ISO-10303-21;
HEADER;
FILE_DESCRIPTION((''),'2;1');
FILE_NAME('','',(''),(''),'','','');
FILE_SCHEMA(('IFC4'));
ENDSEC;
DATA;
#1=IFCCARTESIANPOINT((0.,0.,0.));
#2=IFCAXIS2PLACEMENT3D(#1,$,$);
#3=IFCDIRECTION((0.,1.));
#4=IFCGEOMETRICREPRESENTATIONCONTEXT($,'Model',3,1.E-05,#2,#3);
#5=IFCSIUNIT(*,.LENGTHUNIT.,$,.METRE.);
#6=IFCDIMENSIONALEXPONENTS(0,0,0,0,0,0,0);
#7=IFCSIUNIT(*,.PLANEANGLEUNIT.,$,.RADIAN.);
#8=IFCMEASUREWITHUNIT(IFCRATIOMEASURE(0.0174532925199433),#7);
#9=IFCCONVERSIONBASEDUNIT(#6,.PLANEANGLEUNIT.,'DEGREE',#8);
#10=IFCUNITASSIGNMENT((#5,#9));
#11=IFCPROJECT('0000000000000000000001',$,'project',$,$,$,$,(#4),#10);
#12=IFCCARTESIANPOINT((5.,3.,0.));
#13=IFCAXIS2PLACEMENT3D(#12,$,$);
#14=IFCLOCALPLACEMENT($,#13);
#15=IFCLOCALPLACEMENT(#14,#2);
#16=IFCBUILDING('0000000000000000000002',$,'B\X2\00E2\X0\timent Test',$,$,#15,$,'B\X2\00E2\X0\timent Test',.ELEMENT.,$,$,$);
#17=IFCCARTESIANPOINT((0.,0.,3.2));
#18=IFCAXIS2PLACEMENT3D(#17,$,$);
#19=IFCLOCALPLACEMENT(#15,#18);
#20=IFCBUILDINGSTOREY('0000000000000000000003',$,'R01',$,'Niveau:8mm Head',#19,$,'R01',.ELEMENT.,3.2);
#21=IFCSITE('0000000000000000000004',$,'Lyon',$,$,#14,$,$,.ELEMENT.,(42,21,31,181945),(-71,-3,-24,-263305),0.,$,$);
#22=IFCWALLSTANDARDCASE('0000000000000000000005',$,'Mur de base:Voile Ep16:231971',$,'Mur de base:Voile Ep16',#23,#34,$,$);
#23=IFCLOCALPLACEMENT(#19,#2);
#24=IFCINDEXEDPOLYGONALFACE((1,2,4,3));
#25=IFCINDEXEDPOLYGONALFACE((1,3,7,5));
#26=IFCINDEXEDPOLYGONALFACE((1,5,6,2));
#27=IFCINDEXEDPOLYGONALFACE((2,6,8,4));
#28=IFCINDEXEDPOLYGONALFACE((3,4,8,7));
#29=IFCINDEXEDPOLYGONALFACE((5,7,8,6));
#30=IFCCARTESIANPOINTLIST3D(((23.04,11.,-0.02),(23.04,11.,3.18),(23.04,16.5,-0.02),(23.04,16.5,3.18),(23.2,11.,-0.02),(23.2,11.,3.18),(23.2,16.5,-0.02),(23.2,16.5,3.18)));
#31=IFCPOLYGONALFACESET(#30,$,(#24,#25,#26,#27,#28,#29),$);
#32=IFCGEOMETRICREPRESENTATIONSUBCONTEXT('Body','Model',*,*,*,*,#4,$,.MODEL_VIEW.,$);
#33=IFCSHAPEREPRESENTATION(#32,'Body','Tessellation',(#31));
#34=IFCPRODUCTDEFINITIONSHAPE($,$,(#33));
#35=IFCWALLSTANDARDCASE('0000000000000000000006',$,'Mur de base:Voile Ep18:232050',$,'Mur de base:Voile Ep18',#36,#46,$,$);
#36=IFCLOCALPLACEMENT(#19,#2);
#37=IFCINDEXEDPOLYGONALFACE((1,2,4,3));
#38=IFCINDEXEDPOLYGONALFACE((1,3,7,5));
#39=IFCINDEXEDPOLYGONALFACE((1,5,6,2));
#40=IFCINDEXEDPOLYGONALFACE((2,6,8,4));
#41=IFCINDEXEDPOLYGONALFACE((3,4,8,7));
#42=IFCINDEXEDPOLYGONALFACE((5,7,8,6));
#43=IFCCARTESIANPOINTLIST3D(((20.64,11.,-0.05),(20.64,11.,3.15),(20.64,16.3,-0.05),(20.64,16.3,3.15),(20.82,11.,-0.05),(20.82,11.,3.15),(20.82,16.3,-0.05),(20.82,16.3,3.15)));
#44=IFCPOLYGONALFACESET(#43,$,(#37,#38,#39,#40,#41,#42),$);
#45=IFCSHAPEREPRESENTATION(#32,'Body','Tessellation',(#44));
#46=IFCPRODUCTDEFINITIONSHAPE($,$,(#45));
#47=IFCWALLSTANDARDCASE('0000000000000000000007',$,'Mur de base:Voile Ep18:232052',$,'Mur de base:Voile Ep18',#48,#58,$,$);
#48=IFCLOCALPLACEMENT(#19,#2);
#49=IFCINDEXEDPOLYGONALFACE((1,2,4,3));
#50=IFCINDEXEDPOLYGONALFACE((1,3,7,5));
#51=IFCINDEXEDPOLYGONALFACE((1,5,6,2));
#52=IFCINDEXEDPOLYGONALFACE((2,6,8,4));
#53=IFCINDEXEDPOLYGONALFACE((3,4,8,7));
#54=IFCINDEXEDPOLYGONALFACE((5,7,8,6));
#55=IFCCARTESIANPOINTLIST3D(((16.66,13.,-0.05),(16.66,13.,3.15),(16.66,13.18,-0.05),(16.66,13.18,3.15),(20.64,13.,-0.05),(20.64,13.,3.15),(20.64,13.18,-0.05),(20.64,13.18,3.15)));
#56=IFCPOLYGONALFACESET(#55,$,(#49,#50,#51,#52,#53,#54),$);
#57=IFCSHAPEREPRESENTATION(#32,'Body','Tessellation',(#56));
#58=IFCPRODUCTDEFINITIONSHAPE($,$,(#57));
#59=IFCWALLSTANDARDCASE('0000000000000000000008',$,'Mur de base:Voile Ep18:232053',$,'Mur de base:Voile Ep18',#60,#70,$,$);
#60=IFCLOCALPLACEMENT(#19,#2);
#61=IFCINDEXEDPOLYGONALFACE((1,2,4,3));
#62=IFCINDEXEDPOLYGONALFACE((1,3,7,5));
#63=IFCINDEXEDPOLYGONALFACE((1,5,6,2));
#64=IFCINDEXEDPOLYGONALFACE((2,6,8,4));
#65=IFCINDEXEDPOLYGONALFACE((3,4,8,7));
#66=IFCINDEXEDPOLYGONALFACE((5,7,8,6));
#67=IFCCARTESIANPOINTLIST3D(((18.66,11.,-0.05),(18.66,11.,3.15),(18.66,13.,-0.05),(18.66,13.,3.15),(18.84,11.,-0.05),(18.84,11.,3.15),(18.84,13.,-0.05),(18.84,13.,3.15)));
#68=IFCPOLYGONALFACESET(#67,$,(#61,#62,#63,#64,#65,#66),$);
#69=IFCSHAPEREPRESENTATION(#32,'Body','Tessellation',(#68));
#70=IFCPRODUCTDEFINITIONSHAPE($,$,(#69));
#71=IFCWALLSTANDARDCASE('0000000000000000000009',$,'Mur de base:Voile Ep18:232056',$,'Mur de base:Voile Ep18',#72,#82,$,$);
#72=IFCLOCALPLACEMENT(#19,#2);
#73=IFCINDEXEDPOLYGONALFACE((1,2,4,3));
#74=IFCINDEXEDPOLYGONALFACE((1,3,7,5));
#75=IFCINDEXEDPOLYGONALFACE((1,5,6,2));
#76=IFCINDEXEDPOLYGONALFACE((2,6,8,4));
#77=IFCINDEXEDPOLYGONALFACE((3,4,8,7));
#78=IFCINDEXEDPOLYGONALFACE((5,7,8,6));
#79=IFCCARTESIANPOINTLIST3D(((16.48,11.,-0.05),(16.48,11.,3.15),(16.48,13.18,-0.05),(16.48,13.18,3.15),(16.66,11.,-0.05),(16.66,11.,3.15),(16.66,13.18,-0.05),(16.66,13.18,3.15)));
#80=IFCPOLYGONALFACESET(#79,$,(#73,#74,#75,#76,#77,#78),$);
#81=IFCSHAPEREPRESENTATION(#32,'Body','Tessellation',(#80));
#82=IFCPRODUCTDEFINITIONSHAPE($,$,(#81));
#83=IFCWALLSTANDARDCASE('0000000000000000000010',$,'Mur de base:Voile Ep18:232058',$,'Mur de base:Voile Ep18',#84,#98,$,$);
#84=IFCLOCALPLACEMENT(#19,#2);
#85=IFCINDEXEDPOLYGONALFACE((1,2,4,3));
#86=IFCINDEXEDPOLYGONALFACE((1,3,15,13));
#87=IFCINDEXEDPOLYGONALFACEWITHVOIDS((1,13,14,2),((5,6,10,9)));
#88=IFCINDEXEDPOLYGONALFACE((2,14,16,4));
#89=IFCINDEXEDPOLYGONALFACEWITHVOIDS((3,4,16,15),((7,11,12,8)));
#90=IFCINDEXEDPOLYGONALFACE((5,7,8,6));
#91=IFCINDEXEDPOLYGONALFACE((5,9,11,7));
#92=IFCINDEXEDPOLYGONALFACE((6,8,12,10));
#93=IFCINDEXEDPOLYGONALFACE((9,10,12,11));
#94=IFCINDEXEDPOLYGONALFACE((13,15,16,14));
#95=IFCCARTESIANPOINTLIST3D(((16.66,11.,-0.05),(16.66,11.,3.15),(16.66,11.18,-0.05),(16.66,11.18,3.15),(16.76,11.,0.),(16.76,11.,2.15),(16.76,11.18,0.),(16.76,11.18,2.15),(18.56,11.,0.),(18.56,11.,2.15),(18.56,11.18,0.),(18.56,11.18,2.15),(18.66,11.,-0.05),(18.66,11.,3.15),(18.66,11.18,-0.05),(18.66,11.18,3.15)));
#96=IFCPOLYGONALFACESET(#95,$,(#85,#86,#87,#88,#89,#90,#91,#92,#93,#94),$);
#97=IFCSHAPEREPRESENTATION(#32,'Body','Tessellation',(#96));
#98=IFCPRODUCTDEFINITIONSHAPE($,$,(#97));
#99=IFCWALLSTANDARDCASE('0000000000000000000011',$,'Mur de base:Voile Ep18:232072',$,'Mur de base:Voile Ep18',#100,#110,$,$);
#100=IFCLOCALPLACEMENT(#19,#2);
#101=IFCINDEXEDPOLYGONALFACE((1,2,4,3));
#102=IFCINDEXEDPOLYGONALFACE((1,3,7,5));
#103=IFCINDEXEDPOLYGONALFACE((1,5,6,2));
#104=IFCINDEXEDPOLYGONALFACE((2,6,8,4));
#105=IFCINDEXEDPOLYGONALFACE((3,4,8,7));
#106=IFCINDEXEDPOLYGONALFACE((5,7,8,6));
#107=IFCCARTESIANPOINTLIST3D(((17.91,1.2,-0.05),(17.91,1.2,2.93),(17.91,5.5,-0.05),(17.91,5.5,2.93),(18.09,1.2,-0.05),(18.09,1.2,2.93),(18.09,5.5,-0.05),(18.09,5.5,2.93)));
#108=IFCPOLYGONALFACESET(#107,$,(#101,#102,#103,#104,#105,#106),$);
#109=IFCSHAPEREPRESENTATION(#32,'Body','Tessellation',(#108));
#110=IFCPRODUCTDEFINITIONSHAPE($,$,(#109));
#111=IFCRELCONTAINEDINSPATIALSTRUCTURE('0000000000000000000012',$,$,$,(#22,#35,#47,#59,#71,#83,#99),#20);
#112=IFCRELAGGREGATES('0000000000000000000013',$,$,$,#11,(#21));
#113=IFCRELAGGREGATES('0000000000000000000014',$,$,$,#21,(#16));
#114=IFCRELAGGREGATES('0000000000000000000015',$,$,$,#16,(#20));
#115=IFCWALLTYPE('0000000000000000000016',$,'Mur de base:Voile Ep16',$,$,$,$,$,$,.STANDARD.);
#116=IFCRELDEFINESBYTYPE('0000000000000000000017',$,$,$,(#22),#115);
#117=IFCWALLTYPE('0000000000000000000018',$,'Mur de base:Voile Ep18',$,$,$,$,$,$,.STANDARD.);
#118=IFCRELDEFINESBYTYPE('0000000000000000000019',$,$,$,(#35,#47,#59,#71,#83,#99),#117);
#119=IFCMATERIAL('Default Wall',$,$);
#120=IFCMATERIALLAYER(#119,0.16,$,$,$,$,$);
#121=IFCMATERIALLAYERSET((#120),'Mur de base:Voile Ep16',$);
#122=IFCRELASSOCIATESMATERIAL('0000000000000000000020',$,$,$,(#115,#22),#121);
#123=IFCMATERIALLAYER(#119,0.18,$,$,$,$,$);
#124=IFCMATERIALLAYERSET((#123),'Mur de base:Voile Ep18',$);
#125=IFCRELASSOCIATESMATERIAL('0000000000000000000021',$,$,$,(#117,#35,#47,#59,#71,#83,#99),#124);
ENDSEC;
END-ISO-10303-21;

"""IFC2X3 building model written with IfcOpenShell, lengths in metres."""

from ifc_helpers import new_model, entity, si_unit, converted_unit, direction, frame, frame_2d, origin, place, context, subcontext, project, spatial, rectangle, extrude, material, layer, layer_set, layer_usage, type_object, element, save


model = new_model("IFC2X3")

# Units and contexts
model_context = context("Model", 3, precision=1e-05, world=origin(), true_north=direction((0.0, 1.0)))
body_context = subcontext(model_context, "Body", "Model", "MODEL_VIEW")
ifc_project = project(units=[si_unit("LENGTHUNIT", "METRE"), converted_unit("PLANEANGLEUNIT", "DEGREE", entity("IfcRatioMeasure", 0.0174532925199433), si_unit("PLANEANGLEUNIT", "RADIAN"), dimensions=[0, 0, 0, 0, 0, 0, 0])], contexts=[model_context])

# Site, building, storey
site_placement = place(None, frame((5.0, 3.0, 0.0)))
site = spatial("IfcSite", under=ifc_project, at=site_placement, Name="Lyon", CompositionType="ELEMENT", RefLatitude=(42, 21, 31, 181945), RefLongitude=(-71, -3, -24, -263305), RefElevation=0.0)
building_placement = place(site_placement, origin())
building = spatial("IfcBuilding", under=site, at=building_placement, Name="Bâtiment Test", LongName="Bâtiment Test", CompositionType="ELEMENT")
storey_placement = place(building_placement, frame((0.0, 0.0, 3.2)))
storey = spatial("IfcBuildingStorey", under=building, at=storey_placement, Name="R01", ObjectType="Niveau:8mm Head", LongName="R01", CompositionType="ELEMENT", Elevation=3.2)

# Shared definitions
ifc_material_1 = material(Name="Default Wall")

# Walls
ifc_layer_1 = layer(ifc_material_1, 0.16)
ifc_layer_set_1 = layer_set([ifc_layer_1], Name="Mur de base:Voile Ep16")
wall_type_1 = type_object("IfcWallType", Name="Mur de base:Voile Ep16", PredefinedType="STANDARD", material=ifc_layer_set_1)
ifc_layer_usage_1 = layer_usage(ifc_layer_set_1, "AXIS2", "NEGATIVE", 0.08)
wall_1_placement = place(storey_placement, frame((23.12, 11.0, -0.02), z_axis=(0.0, 0.0, 1.0), x_axis=(0.0, 1.0, 0.0)))
element("IfcWallStandardCase", 1, at=wall_1_placement, inside=storey, type_object=wall_type_1, material=ifc_layer_usage_1, Name="Mur de base:Voile Ep16:231971", ObjectType="Mur de base:Voile Ep16", context=body_context, shape_type="SweptSolid", body=[
    extrude(rectangle(XDim=5.5, YDim=0.16, at=frame_2d((2.75, 0.0), x_axis=(-1.0, 0.0))), origin(), (0.0, 0.0, 1.0), 3.2),
])
ifc_layer_2 = layer(ifc_material_1, 0.18)
ifc_layer_set_2 = layer_set([ifc_layer_2], Name="Mur de base:Voile Ep18")
ifc_layer_usage_2 = layer_usage(ifc_layer_set_2, "AXIS2", "NEGATIVE", 0.09)
wall_type_2 = type_object("IfcWallType", Name="Mur de base:Voile Ep18", PredefinedType="STANDARD", material=ifc_layer_set_2)
wall_2_placement = place(storey_placement, frame((20.73, 16.3, -0.05), z_axis=(0.0, 0.0, 1.0), x_axis=(0.0, -1.0, 0.0)))
element("IfcWallStandardCase", 2, at=wall_2_placement, inside=storey, type_object=wall_type_2, material=ifc_layer_usage_2, Name="Mur de base:Voile Ep18:232050", ObjectType="Mur de base:Voile Ep18", context=body_context, shape_type="SweptSolid", body=[
    extrude(rectangle(XDim=5.3, YDim=0.18, at=frame_2d((2.65, 0.0), x_axis=(-1.0, 0.0))), origin(), (0.0, 0.0, 1.0), 3.2),
])
ifc_layer_usage_3 = layer_usage(ifc_layer_set_2, "AXIS2", "NEGATIVE", 0.09)
wall_3_placement = place(storey_placement, frame((20.64, 13.09, -0.05), z_axis=(0.0, 0.0, 1.0), x_axis=(-1.0, 0.0, 0.0)))
element("IfcWallStandardCase", 3, at=wall_3_placement, inside=storey, type_object=wall_type_2, material=ifc_layer_usage_3, Name="Mur de base:Voile Ep18:232052", ObjectType="Mur de base:Voile Ep18", context=body_context, shape_type="SweptSolid", body=[
    extrude(rectangle(XDim=3.98, YDim=0.18, at=frame_2d((1.99, 0.0), x_axis=(-1.0, 0.0))), origin(), (0.0, 0.0, 1.0), 3.2),
])
ifc_layer_usage_4 = layer_usage(ifc_layer_set_2, "AXIS2", "NEGATIVE", 0.09)
wall_4_placement = place(storey_placement, frame((18.75, 13.0, -0.05), z_axis=(0.0, 0.0, 1.0), x_axis=(0.0, -1.0, 0.0)))
element("IfcWallStandardCase", 4, at=wall_4_placement, inside=storey, type_object=wall_type_2, material=ifc_layer_usage_4, Name="Mur de base:Voile Ep18:232053", ObjectType="Mur de base:Voile Ep18", context=body_context, shape_type="SweptSolid", body=[
    extrude(rectangle(XDim=2.0, YDim=0.18, at=frame_2d((1.0, 0.0), x_axis=(-1.0, 0.0))), origin(), (0.0, 0.0, 1.0), 3.2),
])
ifc_layer_usage_5 = layer_usage(ifc_layer_set_2, "AXIS2", "NEGATIVE", 0.09)
wall_5_placement = place(storey_placement, frame((16.57, 13.18, -0.05), z_axis=(0.0, 0.0, 1.0), x_axis=(0.0, -1.0, 0.0)))
element("IfcWallStandardCase", 5, at=wall_5_placement, inside=storey, type_object=wall_type_2, material=ifc_layer_usage_5, Name="Mur de base:Voile Ep18:232056", ObjectType="Mur de base:Voile Ep18", context=body_context, shape_type="SweptSolid", body=[
    extrude(rectangle(XDim=2.18, YDim=0.18, at=frame_2d((1.09, 0.0), x_axis=(-1.0, 0.0))), origin(), (0.0, 0.0, 1.0), 3.2),
])

# Wall, opening
ifc_layer_usage_6 = layer_usage(ifc_layer_set_2, "AXIS2", "POSITIVE", -0.09)
wall_6_placement = place(storey_placement, frame((16.66, 11.09, -0.05)))
wall_6 = element("IfcWallStandardCase", 6, at=wall_6_placement, inside=storey, type_object=wall_type_2, material=ifc_layer_usage_6, Name="Mur de base:Voile Ep18:232058", ObjectType="Mur de base:Voile Ep18", context=body_context, shape_type="SweptSolid", body=[
    extrude(rectangle(XDim=2.0, YDim=0.18, at=frame_2d((1.0, 0.0), x_axis=(-1.0, 0.0))), origin(), (0.0, 0.0, 1.0), 3.2),
])
opening_1_placement = place(wall_6_placement, origin())
element("IfcOpeningElement", 7, at=opening_1_placement, cuts=wall_6, ObjectType="Opening", context=body_context, shape_type="SweptSolid", body=[
    extrude(rectangle(XDim=2.15, YDim=1.8, at=frame_2d((0.0, 0.0), x_axis=(0.0, 1.0))), frame((1.0, -0.09, 1.125), z_axis=(0.0, 1.0, 0.0), x_axis=(1.0, 0.0, 0.0)), (0.0, 0.0, 1.0), 0.18),
])

# Wall
ifc_layer_usage_7 = layer_usage(ifc_layer_set_2, "AXIS2", "NEGATIVE", 0.09)
wall_7_placement = place(storey_placement, frame((18.0, 1.2, -0.05), z_axis=(0.0, 0.0, 1.0), x_axis=(0.0, 1.0, 0.0)))
element("IfcWallStandardCase", 8, at=wall_7_placement, inside=storey, type_object=wall_type_2, material=ifc_layer_usage_7, Name="Mur de base:Voile Ep18:232072", ObjectType="Mur de base:Voile Ep18", context=body_context, shape_type="SweptSolid", body=[
    extrude(rectangle(XDim=4.3, YDim=0.18, at=frame_2d((2.15, 0.0), x_axis=(-1.0, 0.0))), origin(), (0.0, 0.0, 1.0), 2.98),
])

save(model, "model.ifc")
